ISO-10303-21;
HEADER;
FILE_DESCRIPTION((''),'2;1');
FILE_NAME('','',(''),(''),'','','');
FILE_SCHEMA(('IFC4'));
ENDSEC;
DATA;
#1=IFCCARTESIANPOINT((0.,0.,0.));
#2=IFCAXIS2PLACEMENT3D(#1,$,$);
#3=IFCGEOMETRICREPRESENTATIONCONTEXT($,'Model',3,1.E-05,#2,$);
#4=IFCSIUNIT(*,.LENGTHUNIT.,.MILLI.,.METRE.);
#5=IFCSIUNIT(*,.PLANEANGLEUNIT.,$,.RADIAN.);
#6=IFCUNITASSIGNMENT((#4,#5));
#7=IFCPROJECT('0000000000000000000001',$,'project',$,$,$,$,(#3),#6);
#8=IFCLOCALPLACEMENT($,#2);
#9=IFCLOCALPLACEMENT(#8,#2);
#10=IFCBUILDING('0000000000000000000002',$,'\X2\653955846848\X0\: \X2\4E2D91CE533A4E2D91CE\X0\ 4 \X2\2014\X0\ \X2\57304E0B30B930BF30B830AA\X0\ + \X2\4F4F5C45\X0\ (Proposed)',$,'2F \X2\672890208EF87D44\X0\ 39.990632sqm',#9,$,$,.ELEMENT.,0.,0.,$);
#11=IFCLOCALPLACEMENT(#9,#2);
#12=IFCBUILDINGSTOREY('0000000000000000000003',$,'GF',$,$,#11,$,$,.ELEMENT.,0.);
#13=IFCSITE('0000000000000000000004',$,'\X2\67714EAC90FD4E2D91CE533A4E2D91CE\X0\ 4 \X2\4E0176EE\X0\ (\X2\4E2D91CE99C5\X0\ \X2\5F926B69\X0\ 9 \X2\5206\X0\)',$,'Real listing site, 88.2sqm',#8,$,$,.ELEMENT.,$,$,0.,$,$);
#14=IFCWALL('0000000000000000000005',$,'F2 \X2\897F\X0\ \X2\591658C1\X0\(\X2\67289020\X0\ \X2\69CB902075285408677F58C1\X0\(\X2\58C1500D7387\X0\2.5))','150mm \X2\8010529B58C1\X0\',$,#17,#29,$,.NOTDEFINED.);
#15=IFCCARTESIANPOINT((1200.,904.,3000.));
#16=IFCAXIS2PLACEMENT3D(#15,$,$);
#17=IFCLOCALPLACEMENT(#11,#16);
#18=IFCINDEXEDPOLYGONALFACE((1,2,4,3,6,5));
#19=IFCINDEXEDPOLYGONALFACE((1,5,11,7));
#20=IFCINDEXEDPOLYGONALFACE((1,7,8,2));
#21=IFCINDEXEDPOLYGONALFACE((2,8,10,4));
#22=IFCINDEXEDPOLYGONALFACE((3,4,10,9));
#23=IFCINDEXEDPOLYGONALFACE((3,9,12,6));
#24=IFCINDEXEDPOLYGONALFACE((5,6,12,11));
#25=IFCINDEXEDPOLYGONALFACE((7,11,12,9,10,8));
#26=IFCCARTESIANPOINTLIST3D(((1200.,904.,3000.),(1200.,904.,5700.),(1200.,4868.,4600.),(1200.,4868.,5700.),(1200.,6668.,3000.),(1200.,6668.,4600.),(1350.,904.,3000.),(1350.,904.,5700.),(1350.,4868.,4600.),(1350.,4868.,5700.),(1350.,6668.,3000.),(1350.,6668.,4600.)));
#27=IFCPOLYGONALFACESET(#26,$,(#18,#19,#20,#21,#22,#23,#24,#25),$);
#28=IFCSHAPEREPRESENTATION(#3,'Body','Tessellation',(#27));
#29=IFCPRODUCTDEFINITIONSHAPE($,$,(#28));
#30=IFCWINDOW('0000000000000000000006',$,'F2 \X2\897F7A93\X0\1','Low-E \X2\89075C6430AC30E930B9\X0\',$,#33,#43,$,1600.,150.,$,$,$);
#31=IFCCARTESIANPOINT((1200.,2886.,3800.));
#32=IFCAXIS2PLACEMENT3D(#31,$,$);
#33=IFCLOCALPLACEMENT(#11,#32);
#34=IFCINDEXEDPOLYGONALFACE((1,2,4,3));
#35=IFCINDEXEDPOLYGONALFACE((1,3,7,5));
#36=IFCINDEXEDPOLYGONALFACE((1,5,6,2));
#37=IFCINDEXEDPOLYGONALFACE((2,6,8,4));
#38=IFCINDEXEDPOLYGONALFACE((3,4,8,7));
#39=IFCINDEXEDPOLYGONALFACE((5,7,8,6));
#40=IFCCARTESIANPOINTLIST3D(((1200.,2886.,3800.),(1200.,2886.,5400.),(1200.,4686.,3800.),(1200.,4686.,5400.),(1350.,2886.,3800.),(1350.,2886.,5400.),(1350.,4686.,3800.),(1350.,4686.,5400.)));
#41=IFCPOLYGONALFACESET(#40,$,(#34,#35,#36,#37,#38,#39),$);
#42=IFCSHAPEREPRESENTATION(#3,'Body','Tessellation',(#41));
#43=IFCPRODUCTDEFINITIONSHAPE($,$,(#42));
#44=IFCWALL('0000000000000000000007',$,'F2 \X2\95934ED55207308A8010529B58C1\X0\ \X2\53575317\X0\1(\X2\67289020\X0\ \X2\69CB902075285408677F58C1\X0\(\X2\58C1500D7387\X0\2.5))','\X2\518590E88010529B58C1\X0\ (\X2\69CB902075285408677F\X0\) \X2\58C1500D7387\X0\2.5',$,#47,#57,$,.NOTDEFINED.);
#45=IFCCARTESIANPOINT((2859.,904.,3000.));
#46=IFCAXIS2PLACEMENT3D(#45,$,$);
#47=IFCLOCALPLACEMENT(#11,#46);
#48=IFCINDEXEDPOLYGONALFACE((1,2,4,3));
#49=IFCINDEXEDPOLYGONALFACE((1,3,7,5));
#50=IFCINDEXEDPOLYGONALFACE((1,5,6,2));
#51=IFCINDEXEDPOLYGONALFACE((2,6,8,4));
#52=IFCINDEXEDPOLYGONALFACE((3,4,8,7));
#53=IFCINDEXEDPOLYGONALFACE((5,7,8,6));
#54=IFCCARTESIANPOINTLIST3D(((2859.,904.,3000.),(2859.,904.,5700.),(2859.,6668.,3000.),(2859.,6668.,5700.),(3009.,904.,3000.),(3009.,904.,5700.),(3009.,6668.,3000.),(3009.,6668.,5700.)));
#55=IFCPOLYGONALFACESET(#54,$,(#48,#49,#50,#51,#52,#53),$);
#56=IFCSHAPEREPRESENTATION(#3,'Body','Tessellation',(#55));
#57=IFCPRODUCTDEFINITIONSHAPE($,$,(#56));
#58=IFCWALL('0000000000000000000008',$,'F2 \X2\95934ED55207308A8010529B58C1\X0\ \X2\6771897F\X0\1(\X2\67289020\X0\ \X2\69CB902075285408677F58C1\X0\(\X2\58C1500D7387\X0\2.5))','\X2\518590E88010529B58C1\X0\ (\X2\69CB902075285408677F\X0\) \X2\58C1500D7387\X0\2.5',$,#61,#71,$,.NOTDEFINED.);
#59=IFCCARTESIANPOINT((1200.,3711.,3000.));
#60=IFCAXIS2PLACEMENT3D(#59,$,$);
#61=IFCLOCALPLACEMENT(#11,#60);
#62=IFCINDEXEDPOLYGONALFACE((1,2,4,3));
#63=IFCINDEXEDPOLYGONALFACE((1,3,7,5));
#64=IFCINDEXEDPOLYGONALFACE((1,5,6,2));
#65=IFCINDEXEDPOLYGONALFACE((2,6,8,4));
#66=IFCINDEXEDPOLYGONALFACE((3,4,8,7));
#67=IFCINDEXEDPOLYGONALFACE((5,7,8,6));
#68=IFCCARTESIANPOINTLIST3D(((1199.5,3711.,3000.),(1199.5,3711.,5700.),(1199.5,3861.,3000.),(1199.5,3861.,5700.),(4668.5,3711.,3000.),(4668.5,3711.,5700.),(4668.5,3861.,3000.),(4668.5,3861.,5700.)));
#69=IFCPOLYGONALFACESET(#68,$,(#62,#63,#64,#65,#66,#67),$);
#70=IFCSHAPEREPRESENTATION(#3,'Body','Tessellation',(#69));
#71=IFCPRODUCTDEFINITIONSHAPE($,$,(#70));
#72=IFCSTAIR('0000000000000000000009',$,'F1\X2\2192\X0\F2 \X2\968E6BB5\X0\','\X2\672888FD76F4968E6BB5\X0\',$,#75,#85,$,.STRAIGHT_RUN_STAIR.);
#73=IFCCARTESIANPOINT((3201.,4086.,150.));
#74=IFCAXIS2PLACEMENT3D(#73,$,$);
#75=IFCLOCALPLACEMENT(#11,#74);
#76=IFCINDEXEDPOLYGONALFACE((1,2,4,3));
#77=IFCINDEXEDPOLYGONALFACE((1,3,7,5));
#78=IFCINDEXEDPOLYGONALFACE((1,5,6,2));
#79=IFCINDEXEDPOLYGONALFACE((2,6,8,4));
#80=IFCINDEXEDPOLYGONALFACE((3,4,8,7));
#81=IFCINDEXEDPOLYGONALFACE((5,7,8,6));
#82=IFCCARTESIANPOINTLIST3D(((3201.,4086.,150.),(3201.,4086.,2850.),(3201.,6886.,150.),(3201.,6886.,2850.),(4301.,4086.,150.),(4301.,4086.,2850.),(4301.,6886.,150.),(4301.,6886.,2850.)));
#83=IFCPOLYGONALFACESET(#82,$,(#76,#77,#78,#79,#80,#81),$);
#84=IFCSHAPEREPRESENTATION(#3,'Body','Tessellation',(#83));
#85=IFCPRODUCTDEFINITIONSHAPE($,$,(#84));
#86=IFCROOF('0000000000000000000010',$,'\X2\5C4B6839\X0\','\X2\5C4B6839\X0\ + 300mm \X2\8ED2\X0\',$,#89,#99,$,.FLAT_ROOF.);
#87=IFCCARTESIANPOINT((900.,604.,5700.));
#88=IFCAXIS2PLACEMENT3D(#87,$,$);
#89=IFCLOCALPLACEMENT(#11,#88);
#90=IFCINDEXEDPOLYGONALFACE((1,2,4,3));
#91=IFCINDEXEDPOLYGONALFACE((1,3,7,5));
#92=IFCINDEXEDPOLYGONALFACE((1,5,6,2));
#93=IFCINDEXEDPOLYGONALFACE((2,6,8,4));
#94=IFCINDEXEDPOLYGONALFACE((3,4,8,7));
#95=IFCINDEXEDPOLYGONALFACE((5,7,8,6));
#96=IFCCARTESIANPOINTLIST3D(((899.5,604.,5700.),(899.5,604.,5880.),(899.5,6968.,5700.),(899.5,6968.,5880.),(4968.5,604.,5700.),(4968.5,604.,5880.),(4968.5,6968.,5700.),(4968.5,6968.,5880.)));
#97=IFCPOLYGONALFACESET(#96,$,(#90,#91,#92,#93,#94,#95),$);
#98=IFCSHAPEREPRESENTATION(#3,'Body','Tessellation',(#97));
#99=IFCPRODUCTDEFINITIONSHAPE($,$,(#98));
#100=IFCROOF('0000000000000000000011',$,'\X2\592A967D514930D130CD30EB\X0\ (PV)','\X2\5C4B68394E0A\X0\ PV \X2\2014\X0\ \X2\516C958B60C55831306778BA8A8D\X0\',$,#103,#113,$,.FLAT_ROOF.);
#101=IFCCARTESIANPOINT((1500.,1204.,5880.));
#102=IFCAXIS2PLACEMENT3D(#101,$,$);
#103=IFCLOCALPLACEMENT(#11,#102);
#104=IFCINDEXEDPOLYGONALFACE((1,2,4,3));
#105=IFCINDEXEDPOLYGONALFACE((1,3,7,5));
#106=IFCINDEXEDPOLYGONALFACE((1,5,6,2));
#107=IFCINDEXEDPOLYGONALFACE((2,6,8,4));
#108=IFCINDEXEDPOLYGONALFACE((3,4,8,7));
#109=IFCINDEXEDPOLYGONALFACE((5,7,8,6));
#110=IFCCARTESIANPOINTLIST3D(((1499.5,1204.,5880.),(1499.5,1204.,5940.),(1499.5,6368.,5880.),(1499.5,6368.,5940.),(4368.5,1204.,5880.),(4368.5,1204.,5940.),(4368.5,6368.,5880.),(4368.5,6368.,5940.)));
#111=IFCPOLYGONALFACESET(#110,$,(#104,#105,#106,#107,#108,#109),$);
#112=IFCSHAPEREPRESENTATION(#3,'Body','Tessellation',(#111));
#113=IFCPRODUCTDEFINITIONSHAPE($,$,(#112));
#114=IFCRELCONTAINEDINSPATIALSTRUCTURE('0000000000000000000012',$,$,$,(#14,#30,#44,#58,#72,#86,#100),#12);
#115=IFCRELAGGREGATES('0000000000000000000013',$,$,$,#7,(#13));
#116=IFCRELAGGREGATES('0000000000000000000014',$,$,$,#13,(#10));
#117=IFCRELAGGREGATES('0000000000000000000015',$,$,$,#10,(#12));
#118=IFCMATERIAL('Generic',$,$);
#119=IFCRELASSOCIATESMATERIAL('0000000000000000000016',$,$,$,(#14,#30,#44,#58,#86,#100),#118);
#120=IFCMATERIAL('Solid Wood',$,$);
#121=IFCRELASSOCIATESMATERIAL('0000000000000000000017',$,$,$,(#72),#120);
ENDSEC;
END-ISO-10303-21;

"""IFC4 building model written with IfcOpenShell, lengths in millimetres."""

from ifc_helpers import new_model, si_unit, frame, frame_2d, origin, place, context, project, spatial, rectangle, extrude, material, element, fill, save


model = new_model("IFC4")

# Units and contexts
model_context = context("Model", 3, precision=1e-05, world=origin())
ifc_project = project(units=[si_unit("LENGTHUNIT", "METRE", prefix="MILLI"), si_unit("PLANEANGLEUNIT", "RADIAN")], contexts=[model_context])

# Site, building, storey
site_placement = place(None, origin())
site = spatial("IfcSite", under=ifc_project, at=site_placement, Name="東京都中野区中野 4 丁目 (中野駅 徒歩 9 分)", ObjectType="Real listing site, 88.2sqm", CompositionType="ELEMENT", RefElevation=0.0)
building_placement = place(site_placement, origin())
building = spatial("IfcBuilding", under=site, at=building_placement, Name="改善案: 中野区中野 4 — 地下スタジオ + 住居 (Proposed)", ObjectType="2F 木造軸組 39.990632sqm", CompositionType="ELEMENT", ElevationOfRefHeight=0.0, ElevationOfTerrain=0.0)
storey_placement = place(building_placement, origin())
storey = spatial("IfcBuildingStorey", under=building, at=storey_placement, Name="GF", CompositionType="ELEMENT", Elevation=0.0)

# Shared definitions
ifc_material_1 = material(Name="Generic")

# Shared definitions
ifc_material_2 = material(Name="Solid Wood")

# Wall, opening, window
wall_1_placement = place(storey_placement, frame((1200.0, 904.0, 3000.0)))
wall_1 = element("IfcWall", 1, at=wall_1_placement, inside=storey, material=ifc_material_1, Name="F2 西 外壁(木造 構造用合板壁(壁倍率2.5))", Description="150mm 耐力壁", PredefinedType="NOTDEFINED", context=model_context, shape_type="SweptSolid", body=[
    extrude(rectangle(XDim=150.0, YDim=5764.0, at=frame_2d((75.0, 2882.0))), frame((1200.0, 904.0, 3000.0)), (0.0, 0.0, 1.0), 2700.0),
])
opening_1_placement = place(storey_placement, frame((1200.0, 2886.0, 3800.0)))
opening_1 = element("IfcOpeningElement", 2, at=opening_1_placement, cuts=wall_1, PredefinedType="NOTDEFINED", context=model_context, shape_type="SweptSolid", body=[
    extrude(rectangle(XDim=150.0, YDim=1800.0, at=frame_2d((75.0, 900.0))), frame((1200.0, 2886.0, 3800.0)), (0.0, 0.0, 1.0), 1600.0),
])
window_1_placement = place(storey_placement, frame((1200.0, 2886.0, 3800.0)))
window_1 = element("IfcWindow", 3, at=window_1_placement, inside=storey, material=ifc_material_1, Name="F2 西窓1", Description="Low-E 複層ガラス", OverallHeight=1600.0, OverallWidth=150.0, context=model_context, shape_type="SweptSolid", body=[
    extrude(rectangle(XDim=150.0, YDim=1800.0, at=frame_2d((75.0, 900.0))), frame((1200.0, 2886.0, 3800.0)), (0.0, 0.0, 1.0), 1600.0),
])
fill(opening_1, window_1)

# Walls
wall_2_placement = place(storey_placement, frame((2859.0, 904.0, 3000.0)))
element("IfcWall", 4, at=wall_2_placement, inside=storey, material=ifc_material_1, Name="F2 間仕切り耐力壁 南北1(木造 構造用合板壁(壁倍率2.5))", Description="内部耐力壁 (構造用合板) 壁倍率2.5", PredefinedType="NOTDEFINED", context=model_context, shape_type="SweptSolid", body=[
    extrude(rectangle(XDim=150.0, YDim=5764.0, at=frame_2d((75.0, 2882.0))), frame((2859.0, 904.0, 3000.0)), (0.0, 0.0, 1.0), 2700.0),
])
wall_3_placement = place(storey_placement, frame((1200.0, 3711.0, 3000.0)))
element("IfcWall", 5, at=wall_3_placement, inside=storey, material=ifc_material_1, Name="F2 間仕切り耐力壁 東西1(木造 構造用合板壁(壁倍率2.5))", Description="内部耐力壁 (構造用合板) 壁倍率2.5", PredefinedType="NOTDEFINED", context=model_context, shape_type="SweptSolid", body=[
    extrude(rectangle(XDim=3469.0, YDim=150.0, at=frame_2d((1734.0, 75.0))), frame((1200.0, 3711.0, 3000.0)), (0.0, 0.0, 1.0), 2700.0),
])

# Stair
stair_placement = place(storey_placement, frame((3201.0, 4086.0, 150.0)))
element("IfcStair", 6, at=stair_placement, inside=storey, material=ifc_material_2, Name="F1→F2 階段", Description="木製直階段", PredefinedType="STRAIGHT_RUN_STAIR", context=model_context, shape_type="SweptSolid", body=[
    extrude(rectangle(XDim=1100.0, YDim=2800.0, at=frame_2d((550.0, 1400.0))), frame((3201.0, 4086.0, 150.0)), (0.0, 0.0, 1.0), 2700.0),
])

# Roofs
roof_1_placement = place(storey_placement, frame((900.0, 604.0, 5700.0)))
element("IfcRoof", 7, at=roof_1_placement, inside=storey, material=ifc_material_1, Name="屋根", Description="屋根 + 300mm 軒", PredefinedType="FLAT_ROOF", context=model_context, shape_type="SweptSolid", body=[
    extrude(rectangle(XDim=4069.0, YDim=6364.0, at=frame_2d((2034.0, 3182.0))), frame((900.0, 604.0, 5700.0)), (0.0, 0.0, 1.0), 180.0),
])
roof_2_placement = place(storey_placement, frame((1500.0, 1204.0, 5880.0)))
element("IfcRoof", 8, at=roof_2_placement, inside=storey, material=ifc_material_1, Name="太陽光パネル (PV)", Description="屋根上 PV — 公開情報で確認", PredefinedType="FLAT_ROOF", context=model_context, shape_type="SweptSolid", body=[
    extrude(rectangle(XDim=2869.0, YDim=5164.0, at=frame_2d((1434.0, 2582.0))), frame((1500.0, 1204.0, 5880.0)), (0.0, 0.0, 1.0), 60.0),
])

save(model, "model.ifc")
